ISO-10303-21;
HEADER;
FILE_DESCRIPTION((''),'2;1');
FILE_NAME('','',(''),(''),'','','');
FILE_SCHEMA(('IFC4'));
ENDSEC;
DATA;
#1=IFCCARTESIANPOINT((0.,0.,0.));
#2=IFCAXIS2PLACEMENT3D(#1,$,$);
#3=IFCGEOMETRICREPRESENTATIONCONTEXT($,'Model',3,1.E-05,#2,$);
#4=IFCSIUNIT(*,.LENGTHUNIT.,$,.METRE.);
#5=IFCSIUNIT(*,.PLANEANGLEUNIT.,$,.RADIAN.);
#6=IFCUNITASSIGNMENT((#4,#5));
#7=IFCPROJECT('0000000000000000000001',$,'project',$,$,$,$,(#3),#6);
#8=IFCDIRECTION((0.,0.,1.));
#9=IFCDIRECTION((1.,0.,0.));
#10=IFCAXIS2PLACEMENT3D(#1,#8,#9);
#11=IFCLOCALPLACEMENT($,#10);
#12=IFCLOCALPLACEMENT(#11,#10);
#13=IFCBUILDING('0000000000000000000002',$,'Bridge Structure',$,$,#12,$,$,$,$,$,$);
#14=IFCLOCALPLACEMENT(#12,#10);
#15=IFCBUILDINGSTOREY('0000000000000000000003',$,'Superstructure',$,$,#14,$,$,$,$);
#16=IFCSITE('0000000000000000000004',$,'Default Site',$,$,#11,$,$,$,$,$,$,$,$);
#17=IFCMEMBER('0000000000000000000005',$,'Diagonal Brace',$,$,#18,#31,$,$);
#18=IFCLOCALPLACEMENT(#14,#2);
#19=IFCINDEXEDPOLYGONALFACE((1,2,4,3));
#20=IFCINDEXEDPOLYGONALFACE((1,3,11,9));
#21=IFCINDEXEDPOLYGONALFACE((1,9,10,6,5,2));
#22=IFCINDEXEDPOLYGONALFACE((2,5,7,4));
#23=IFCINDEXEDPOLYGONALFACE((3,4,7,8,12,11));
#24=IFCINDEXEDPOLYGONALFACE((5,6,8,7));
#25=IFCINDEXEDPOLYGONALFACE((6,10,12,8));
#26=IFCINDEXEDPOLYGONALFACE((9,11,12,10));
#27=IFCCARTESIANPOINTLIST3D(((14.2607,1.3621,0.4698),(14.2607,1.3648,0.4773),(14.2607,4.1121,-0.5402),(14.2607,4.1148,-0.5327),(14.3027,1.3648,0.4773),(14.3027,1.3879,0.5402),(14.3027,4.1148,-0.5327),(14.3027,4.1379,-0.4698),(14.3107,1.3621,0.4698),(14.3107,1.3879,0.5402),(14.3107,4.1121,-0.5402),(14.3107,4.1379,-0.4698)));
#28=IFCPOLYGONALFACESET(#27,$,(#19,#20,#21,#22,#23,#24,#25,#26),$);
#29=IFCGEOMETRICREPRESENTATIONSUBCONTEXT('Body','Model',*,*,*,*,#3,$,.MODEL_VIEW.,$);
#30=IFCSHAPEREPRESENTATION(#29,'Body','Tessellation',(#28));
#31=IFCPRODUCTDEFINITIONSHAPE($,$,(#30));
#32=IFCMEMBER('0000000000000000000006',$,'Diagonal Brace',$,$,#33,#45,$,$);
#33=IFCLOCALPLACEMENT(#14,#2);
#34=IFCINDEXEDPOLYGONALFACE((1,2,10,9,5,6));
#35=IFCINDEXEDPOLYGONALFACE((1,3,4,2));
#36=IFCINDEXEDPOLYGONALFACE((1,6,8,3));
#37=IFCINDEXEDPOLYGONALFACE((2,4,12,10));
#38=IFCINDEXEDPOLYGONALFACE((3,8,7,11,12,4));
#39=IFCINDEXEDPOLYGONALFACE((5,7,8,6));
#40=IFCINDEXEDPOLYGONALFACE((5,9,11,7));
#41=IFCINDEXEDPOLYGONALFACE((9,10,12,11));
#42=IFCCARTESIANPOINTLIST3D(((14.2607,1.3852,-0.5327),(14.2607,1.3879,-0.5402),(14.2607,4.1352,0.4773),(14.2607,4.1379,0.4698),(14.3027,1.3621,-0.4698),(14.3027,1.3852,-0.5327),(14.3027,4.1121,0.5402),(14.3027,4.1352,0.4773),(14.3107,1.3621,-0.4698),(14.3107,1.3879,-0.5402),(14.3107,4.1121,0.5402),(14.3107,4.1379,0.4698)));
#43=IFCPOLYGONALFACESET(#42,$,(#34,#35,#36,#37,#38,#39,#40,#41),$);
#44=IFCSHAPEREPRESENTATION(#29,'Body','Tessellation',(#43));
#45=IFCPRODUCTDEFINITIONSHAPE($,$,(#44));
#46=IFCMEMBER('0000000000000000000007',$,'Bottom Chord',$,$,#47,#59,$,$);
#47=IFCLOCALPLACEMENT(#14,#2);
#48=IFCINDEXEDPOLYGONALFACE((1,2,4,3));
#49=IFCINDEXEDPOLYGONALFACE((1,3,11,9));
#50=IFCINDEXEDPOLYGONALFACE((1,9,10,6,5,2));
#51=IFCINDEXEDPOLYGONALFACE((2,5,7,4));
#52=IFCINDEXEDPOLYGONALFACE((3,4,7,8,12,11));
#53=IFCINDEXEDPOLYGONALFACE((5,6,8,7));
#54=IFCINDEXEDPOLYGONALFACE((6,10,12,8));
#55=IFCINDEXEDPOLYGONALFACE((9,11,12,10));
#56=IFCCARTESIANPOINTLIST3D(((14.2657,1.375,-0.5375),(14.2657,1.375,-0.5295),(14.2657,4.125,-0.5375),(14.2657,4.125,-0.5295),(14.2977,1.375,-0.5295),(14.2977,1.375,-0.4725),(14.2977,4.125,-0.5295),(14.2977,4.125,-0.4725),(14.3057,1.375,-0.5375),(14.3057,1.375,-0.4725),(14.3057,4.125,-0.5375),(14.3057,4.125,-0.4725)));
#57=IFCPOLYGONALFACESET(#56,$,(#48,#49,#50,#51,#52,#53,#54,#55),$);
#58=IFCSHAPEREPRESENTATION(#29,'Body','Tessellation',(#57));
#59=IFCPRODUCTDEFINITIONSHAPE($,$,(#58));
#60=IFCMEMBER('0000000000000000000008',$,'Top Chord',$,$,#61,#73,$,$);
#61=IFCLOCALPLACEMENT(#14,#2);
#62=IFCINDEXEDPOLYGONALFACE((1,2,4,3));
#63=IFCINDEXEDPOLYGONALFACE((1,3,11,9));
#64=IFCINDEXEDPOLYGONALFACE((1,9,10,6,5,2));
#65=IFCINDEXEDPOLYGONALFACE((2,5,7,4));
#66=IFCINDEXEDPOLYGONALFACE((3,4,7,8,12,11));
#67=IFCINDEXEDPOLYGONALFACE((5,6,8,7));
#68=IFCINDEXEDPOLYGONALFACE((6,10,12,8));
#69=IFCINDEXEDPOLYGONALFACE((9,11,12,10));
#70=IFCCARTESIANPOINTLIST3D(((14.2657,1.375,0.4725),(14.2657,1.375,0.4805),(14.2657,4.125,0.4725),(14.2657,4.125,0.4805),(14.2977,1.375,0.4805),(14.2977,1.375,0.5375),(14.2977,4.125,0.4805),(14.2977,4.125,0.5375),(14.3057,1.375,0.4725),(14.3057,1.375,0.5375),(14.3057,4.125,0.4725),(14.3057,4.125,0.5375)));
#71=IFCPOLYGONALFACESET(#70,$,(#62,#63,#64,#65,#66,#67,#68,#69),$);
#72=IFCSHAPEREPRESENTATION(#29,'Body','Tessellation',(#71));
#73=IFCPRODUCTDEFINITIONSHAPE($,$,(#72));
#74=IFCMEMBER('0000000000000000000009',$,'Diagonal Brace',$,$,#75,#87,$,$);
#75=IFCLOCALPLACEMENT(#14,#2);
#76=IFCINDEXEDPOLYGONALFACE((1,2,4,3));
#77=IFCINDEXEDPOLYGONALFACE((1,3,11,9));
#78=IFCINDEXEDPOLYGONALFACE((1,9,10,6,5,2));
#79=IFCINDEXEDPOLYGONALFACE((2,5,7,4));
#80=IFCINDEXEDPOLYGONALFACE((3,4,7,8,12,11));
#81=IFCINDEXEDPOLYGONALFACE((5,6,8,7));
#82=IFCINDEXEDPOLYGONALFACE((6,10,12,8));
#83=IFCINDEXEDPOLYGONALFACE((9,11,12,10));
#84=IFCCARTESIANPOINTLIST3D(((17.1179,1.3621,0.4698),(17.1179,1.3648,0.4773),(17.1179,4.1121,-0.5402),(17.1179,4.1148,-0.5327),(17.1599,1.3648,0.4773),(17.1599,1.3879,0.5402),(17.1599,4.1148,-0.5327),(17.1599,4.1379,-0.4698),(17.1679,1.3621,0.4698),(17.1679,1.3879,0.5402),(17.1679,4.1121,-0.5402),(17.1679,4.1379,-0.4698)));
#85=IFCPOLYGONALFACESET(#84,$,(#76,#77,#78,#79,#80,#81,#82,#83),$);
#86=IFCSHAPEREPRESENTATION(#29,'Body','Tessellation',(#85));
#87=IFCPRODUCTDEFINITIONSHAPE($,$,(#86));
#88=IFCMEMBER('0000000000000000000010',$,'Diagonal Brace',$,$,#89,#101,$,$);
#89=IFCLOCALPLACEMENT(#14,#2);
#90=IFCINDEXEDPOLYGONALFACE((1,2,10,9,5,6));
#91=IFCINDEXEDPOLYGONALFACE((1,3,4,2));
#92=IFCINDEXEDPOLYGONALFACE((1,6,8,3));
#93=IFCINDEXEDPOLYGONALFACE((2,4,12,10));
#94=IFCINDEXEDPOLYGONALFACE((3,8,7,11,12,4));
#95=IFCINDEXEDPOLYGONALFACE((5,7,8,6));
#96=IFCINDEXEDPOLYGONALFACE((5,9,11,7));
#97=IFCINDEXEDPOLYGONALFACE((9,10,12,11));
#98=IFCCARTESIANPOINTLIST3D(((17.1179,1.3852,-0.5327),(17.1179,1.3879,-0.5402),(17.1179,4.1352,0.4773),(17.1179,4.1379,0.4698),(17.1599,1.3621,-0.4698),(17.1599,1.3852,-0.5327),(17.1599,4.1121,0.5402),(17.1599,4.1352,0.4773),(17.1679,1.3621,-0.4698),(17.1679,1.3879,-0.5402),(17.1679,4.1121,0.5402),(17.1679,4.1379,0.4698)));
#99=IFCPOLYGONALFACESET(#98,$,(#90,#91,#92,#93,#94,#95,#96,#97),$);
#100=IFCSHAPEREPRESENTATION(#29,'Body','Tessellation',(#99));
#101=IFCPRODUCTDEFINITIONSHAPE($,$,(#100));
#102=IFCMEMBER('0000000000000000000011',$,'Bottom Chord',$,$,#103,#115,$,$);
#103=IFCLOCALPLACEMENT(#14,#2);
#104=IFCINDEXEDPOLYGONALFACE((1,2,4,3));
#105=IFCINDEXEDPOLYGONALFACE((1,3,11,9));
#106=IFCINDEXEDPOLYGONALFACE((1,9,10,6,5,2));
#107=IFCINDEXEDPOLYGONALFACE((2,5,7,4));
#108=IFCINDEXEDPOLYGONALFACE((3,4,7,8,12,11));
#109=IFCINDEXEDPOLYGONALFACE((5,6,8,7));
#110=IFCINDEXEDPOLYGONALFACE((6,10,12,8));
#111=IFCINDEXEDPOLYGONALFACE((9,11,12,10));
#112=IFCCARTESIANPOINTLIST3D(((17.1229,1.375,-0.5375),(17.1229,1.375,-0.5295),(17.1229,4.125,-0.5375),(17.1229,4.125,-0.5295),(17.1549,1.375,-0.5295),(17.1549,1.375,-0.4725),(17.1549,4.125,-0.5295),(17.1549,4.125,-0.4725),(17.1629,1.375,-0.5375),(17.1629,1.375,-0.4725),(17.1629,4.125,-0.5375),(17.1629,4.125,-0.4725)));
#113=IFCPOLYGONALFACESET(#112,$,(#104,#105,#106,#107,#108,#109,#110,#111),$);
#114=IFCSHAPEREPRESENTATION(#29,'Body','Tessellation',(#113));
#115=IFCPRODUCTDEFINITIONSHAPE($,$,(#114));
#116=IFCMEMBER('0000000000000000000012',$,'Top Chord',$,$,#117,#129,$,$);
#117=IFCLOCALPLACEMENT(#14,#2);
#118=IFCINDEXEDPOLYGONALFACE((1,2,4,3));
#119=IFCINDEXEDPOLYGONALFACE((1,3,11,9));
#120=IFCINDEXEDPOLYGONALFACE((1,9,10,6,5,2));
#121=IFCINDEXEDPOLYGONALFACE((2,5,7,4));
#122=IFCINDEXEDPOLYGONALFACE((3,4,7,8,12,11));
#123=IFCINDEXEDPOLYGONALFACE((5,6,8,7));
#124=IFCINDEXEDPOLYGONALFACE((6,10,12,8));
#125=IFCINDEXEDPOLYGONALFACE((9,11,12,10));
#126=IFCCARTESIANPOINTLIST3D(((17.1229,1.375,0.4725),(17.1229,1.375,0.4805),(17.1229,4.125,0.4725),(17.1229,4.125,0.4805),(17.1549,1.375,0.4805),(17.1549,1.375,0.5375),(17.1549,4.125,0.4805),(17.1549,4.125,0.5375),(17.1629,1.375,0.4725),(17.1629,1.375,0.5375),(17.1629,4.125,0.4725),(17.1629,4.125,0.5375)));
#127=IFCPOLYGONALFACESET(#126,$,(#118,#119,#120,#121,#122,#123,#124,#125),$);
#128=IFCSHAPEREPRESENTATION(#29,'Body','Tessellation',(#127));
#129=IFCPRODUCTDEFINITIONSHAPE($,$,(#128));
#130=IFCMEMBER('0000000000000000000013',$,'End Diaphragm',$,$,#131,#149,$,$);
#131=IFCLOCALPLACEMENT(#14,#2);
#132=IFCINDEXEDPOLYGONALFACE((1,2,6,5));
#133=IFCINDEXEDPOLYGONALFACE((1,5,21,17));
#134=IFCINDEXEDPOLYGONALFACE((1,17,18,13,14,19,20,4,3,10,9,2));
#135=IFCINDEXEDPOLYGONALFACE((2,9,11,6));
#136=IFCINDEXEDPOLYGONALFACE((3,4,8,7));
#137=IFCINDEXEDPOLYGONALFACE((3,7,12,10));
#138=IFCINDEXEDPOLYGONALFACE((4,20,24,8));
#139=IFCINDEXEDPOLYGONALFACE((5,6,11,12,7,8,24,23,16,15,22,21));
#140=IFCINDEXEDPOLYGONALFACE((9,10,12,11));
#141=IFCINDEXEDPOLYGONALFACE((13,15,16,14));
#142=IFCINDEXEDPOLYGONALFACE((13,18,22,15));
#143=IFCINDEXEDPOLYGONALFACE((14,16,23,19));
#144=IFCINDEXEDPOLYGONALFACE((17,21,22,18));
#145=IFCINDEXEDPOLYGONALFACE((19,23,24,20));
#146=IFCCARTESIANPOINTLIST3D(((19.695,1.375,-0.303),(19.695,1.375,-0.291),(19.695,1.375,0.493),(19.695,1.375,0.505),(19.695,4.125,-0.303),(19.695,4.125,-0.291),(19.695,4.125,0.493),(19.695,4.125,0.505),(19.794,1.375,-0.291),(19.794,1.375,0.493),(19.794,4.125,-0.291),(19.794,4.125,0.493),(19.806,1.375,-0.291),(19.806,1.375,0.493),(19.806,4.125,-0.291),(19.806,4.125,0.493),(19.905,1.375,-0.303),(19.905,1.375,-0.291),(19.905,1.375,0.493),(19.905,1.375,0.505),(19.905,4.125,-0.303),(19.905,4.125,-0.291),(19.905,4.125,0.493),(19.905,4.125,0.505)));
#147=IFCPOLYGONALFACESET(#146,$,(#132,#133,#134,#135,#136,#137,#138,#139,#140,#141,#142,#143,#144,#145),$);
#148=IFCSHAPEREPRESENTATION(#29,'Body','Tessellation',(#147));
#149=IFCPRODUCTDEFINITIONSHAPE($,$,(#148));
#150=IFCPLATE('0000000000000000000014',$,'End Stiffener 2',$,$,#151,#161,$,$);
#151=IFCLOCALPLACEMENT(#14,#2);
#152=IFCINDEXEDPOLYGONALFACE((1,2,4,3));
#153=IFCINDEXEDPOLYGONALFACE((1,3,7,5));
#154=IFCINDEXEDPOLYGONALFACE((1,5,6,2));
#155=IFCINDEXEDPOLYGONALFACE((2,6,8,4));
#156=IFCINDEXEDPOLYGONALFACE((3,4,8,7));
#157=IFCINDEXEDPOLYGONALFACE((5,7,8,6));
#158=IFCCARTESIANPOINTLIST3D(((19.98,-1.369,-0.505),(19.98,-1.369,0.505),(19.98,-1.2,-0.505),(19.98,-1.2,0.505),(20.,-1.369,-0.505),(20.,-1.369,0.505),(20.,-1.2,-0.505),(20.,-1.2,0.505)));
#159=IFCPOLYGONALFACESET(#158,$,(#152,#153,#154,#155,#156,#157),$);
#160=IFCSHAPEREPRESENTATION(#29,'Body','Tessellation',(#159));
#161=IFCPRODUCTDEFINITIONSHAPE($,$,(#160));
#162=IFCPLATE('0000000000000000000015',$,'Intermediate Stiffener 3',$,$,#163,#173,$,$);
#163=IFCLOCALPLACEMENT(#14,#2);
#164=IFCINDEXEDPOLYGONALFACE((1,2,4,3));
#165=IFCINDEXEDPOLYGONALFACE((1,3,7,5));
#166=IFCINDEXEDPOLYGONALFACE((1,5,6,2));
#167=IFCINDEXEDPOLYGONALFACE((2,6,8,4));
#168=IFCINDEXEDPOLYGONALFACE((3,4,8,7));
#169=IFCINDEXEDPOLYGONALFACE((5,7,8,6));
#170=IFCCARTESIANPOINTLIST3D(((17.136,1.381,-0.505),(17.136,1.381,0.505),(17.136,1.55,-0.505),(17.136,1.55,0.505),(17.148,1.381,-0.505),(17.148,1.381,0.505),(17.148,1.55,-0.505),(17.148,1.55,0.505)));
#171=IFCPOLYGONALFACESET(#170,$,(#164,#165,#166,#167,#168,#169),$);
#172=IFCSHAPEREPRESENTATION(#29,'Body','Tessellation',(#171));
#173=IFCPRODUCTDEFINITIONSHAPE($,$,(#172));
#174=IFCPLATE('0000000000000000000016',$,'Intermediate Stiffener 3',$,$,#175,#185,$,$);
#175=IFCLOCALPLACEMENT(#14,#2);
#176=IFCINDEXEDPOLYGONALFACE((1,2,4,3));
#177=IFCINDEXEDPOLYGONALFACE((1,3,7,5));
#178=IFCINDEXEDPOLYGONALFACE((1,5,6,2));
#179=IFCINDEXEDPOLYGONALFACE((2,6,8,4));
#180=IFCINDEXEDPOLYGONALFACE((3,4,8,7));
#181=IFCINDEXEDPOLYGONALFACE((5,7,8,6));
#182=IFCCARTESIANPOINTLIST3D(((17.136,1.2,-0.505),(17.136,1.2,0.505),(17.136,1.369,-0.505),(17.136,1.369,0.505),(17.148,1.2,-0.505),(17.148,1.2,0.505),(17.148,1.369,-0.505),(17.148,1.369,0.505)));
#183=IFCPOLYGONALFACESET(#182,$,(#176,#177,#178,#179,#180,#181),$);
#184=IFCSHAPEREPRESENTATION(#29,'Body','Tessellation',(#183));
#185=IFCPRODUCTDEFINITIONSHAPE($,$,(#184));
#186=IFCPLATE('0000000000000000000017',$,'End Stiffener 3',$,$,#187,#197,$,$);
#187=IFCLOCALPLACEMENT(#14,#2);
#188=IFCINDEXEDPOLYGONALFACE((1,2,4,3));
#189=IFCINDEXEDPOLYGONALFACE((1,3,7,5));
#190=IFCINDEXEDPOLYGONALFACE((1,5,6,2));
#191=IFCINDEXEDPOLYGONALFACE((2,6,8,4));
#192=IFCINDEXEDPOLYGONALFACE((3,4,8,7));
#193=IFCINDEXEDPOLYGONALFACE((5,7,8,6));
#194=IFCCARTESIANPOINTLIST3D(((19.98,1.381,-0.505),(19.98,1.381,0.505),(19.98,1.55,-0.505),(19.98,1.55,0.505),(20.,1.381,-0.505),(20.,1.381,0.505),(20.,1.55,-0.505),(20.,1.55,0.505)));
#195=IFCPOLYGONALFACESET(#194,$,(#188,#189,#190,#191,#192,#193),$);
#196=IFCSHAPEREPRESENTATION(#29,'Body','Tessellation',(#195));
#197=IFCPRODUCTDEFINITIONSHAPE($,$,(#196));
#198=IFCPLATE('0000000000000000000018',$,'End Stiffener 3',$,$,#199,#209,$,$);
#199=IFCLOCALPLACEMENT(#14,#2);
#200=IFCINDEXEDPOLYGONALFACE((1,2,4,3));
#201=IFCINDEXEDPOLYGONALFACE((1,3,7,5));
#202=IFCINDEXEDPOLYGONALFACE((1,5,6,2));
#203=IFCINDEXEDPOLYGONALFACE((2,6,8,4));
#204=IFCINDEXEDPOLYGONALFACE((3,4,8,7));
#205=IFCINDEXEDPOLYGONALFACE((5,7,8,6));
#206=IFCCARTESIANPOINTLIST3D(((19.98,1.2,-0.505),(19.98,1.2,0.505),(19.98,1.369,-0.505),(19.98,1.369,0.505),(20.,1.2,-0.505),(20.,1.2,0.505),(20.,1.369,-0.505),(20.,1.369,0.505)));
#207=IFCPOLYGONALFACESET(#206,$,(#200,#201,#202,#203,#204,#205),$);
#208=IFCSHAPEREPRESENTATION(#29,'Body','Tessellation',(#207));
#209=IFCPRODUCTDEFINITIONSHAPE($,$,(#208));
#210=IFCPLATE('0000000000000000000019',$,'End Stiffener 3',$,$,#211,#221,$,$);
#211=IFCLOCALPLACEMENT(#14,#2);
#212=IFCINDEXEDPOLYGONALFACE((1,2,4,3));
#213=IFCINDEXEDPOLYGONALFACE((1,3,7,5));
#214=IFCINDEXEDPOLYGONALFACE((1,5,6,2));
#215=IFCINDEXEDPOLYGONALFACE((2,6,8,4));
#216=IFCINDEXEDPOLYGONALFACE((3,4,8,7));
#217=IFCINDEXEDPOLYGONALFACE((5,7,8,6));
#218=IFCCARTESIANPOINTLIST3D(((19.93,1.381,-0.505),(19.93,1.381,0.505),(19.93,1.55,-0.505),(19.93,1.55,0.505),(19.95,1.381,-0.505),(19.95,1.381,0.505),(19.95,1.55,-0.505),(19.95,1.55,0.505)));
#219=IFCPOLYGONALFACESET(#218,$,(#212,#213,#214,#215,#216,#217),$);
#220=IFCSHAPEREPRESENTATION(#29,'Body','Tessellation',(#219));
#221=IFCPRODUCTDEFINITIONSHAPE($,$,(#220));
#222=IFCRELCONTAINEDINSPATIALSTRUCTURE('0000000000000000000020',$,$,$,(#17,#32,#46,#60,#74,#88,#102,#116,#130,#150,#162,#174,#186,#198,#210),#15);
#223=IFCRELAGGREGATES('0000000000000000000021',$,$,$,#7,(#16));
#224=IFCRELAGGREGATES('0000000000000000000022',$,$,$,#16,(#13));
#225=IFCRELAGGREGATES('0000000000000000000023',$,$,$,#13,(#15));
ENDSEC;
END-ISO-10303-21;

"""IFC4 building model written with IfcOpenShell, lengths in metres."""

from ifc_helpers import new_model, si_unit, frame, origin, origin_with_axes, origin_2d_with_axis, place, context, subcontext, project, spatial, rectangle, i_section, l_section, extrude, element, save


model = new_model("IFC4")

# Units and contexts
model_context = context("Model", 3, precision=1e-05, world=origin())
body_context = subcontext(model_context, "Body", "Model", "MODEL_VIEW")
ifc_project = project(units=[si_unit("LENGTHUNIT", "METRE"), si_unit("PLANEANGLEUNIT", "RADIAN")], contexts=[model_context])

# Site, building, storey
site_placement = place(None, origin_with_axes())
site = spatial("IfcSite", under=ifc_project, at=site_placement, Name="Default Site")
building_placement = place(site_placement, origin_with_axes())
building = spatial("IfcBuilding", under=site, at=building_placement, Name="Bridge Structure")
storey_placement = place(building_placement, origin_with_axes())
storey = spatial("IfcBuildingStorey", under=building, at=storey_placement, Name="Superstructure")

# Members
for number, where, z_axis, x_axis, name in (
    (1, (14.2857, 1.375, 0.505), (0.0, 0.938692, -0.344756), (-1.0, 0.0, 0.0), "Diagonal Brace"),
    (2, (14.2857, 1.375, -0.505), (0.0, 0.938692, 0.344756), (-1.0, 0.0, 0.0), "Diagonal Brace"),
):
    element("IfcMember", number, at=place(storey_placement, frame(where, z_axis=z_axis, x_axis=x_axis)), inside=storey, Name=name, context=body_context, shape_type="SweptSolid", body=[
        extrude(l_section(Depth=0.075, Width=0.05, Thickness=0.008, at=origin_2d_with_axis()), origin_with_axes(), (0.0, 0.0, 1.0), 2.9296),
    ])
for number, where, z_axis, x_axis, name in (
    (3, (14.2857, 1.375, -0.505), (0.0, 1.0, 0.0), (-1.0, 0.0, 0.0), "Bottom Chord"),
    (4, (14.2857, 1.375, 0.505), (0.0, 1.0, 0.0), (-1.0, 0.0, 0.0), "Top Chord"),
):
    element("IfcMember", number, at=place(storey_placement, frame(where, z_axis=z_axis, x_axis=x_axis)), inside=storey, Name=name, context=body_context, shape_type="SweptSolid", body=[
        extrude(l_section(Depth=0.065, Width=0.04, Thickness=0.008, at=origin_2d_with_axis()), origin_with_axes(), (0.0, 0.0, 1.0), 2.75),
    ])
for number, where, z_axis, x_axis, name in (
    (5, (17.1429, 1.375, 0.505), (0.0, 0.938692, -0.344756), (-1.0, 0.0, 0.0), "Diagonal Brace"),
    (6, (17.1429, 1.375, -0.505), (0.0, 0.938692, 0.344756), (-1.0, 0.0, 0.0), "Diagonal Brace"),
):
    element("IfcMember", number, at=place(storey_placement, frame(where, z_axis=z_axis, x_axis=x_axis)), inside=storey, Name=name, context=body_context, shape_type="SweptSolid", body=[
        extrude(l_section(Depth=0.075, Width=0.05, Thickness=0.008, at=origin_2d_with_axis()), origin_with_axes(), (0.0, 0.0, 1.0), 2.9296),
    ])
for number, where, z_axis, x_axis, name in (
    (7, (17.1429, 1.375, -0.505), (0.0, 1.0, 0.0), (-1.0, 0.0, 0.0), "Bottom Chord"),
    (8, (17.1429, 1.375, 0.505), (0.0, 1.0, 0.0), (-1.0, 0.0, 0.0), "Top Chord"),
):
    element("IfcMember", number, at=place(storey_placement, frame(where, z_axis=z_axis, x_axis=x_axis)), inside=storey, Name=name, context=body_context, shape_type="SweptSolid", body=[
        extrude(l_section(Depth=0.065, Width=0.04, Thickness=0.008, at=origin_2d_with_axis()), origin_with_axes(), (0.0, 0.0, 1.0), 2.75),
    ])
member_placement = place(storey_placement, frame((19.8, 1.375, 0.101), z_axis=(0.0, 1.0, 0.0), x_axis=(-1.0, 0.0, 0.0)))
element("IfcMember", 9, at=member_placement, inside=storey, Name="End Diaphragm", context=body_context, shape_type="SweptSolid", body=[
    extrude(i_section(OverallWidth=0.21, OverallDepth=0.808, WebThickness=0.012, FlangeThickness=0.012, at=origin_2d_with_axis()), origin_with_axes(), (0.0, 0.0, 1.0), 2.75),
])

# Plates
plate_placement = place(storey_placement, frame((19.99, -1.2845, -0.505), z_axis=(0.0, 0.0, 1.0), x_axis=(1.0, 0.0, 0.0)))
element("IfcPlate", 10, at=plate_placement, inside=storey, Name="End Stiffener 2", context=body_context, shape_type="SweptSolid", body=[
    extrude(rectangle(XDim=0.02, YDim=0.169, at=origin_2d_with_axis()), origin_with_axes(), (0.0, 0.0, 1.0), 1.01),
])
for number, where, z_axis, x_axis, name in (
    (11, (17.142, 1.4655, -0.505), (0.0, 0.0, 1.0), (1.0, 0.0, 0.0), "Intermediate Stiffener 3"),
    (12, (17.142, 1.2845, -0.505), (0.0, 0.0, 1.0), (1.0, 0.0, 0.0), "Intermediate Stiffener 3"),
):
    element("IfcPlate", number, at=place(storey_placement, frame(where, z_axis=z_axis, x_axis=x_axis)), inside=storey, Name=name, context=body_context, shape_type="SweptSolid", body=[
        extrude(rectangle(XDim=0.012, YDim=0.169, at=origin_2d_with_axis()), origin_with_axes(), (0.0, 0.0, 1.0), 1.01),
    ])
for number, where, z_axis, x_axis, name in (
    (13, (19.99, 1.4655, -0.505), (0.0, 0.0, 1.0), (1.0, 0.0, 0.0), "End Stiffener 3"),
    (14, (19.99, 1.2845, -0.505), (0.0, 0.0, 1.0), (1.0, 0.0, 0.0), "End Stiffener 3"),
    (15, (19.94, 1.4655, -0.505), (0.0, 0.0, 1.0), (1.0, 0.0, 0.0), "End Stiffener 3"),
):
    element("IfcPlate", number, at=place(storey_placement, frame(where, z_axis=z_axis, x_axis=x_axis)), inside=storey, Name=name, context=body_context, shape_type="SweptSolid", body=[
        extrude(rectangle(XDim=0.02, YDim=0.169, at=origin_2d_with_axis()), origin_with_axes(), (0.0, 0.0, 1.0), 1.01),
    ])

save(model, "model.ifc")
